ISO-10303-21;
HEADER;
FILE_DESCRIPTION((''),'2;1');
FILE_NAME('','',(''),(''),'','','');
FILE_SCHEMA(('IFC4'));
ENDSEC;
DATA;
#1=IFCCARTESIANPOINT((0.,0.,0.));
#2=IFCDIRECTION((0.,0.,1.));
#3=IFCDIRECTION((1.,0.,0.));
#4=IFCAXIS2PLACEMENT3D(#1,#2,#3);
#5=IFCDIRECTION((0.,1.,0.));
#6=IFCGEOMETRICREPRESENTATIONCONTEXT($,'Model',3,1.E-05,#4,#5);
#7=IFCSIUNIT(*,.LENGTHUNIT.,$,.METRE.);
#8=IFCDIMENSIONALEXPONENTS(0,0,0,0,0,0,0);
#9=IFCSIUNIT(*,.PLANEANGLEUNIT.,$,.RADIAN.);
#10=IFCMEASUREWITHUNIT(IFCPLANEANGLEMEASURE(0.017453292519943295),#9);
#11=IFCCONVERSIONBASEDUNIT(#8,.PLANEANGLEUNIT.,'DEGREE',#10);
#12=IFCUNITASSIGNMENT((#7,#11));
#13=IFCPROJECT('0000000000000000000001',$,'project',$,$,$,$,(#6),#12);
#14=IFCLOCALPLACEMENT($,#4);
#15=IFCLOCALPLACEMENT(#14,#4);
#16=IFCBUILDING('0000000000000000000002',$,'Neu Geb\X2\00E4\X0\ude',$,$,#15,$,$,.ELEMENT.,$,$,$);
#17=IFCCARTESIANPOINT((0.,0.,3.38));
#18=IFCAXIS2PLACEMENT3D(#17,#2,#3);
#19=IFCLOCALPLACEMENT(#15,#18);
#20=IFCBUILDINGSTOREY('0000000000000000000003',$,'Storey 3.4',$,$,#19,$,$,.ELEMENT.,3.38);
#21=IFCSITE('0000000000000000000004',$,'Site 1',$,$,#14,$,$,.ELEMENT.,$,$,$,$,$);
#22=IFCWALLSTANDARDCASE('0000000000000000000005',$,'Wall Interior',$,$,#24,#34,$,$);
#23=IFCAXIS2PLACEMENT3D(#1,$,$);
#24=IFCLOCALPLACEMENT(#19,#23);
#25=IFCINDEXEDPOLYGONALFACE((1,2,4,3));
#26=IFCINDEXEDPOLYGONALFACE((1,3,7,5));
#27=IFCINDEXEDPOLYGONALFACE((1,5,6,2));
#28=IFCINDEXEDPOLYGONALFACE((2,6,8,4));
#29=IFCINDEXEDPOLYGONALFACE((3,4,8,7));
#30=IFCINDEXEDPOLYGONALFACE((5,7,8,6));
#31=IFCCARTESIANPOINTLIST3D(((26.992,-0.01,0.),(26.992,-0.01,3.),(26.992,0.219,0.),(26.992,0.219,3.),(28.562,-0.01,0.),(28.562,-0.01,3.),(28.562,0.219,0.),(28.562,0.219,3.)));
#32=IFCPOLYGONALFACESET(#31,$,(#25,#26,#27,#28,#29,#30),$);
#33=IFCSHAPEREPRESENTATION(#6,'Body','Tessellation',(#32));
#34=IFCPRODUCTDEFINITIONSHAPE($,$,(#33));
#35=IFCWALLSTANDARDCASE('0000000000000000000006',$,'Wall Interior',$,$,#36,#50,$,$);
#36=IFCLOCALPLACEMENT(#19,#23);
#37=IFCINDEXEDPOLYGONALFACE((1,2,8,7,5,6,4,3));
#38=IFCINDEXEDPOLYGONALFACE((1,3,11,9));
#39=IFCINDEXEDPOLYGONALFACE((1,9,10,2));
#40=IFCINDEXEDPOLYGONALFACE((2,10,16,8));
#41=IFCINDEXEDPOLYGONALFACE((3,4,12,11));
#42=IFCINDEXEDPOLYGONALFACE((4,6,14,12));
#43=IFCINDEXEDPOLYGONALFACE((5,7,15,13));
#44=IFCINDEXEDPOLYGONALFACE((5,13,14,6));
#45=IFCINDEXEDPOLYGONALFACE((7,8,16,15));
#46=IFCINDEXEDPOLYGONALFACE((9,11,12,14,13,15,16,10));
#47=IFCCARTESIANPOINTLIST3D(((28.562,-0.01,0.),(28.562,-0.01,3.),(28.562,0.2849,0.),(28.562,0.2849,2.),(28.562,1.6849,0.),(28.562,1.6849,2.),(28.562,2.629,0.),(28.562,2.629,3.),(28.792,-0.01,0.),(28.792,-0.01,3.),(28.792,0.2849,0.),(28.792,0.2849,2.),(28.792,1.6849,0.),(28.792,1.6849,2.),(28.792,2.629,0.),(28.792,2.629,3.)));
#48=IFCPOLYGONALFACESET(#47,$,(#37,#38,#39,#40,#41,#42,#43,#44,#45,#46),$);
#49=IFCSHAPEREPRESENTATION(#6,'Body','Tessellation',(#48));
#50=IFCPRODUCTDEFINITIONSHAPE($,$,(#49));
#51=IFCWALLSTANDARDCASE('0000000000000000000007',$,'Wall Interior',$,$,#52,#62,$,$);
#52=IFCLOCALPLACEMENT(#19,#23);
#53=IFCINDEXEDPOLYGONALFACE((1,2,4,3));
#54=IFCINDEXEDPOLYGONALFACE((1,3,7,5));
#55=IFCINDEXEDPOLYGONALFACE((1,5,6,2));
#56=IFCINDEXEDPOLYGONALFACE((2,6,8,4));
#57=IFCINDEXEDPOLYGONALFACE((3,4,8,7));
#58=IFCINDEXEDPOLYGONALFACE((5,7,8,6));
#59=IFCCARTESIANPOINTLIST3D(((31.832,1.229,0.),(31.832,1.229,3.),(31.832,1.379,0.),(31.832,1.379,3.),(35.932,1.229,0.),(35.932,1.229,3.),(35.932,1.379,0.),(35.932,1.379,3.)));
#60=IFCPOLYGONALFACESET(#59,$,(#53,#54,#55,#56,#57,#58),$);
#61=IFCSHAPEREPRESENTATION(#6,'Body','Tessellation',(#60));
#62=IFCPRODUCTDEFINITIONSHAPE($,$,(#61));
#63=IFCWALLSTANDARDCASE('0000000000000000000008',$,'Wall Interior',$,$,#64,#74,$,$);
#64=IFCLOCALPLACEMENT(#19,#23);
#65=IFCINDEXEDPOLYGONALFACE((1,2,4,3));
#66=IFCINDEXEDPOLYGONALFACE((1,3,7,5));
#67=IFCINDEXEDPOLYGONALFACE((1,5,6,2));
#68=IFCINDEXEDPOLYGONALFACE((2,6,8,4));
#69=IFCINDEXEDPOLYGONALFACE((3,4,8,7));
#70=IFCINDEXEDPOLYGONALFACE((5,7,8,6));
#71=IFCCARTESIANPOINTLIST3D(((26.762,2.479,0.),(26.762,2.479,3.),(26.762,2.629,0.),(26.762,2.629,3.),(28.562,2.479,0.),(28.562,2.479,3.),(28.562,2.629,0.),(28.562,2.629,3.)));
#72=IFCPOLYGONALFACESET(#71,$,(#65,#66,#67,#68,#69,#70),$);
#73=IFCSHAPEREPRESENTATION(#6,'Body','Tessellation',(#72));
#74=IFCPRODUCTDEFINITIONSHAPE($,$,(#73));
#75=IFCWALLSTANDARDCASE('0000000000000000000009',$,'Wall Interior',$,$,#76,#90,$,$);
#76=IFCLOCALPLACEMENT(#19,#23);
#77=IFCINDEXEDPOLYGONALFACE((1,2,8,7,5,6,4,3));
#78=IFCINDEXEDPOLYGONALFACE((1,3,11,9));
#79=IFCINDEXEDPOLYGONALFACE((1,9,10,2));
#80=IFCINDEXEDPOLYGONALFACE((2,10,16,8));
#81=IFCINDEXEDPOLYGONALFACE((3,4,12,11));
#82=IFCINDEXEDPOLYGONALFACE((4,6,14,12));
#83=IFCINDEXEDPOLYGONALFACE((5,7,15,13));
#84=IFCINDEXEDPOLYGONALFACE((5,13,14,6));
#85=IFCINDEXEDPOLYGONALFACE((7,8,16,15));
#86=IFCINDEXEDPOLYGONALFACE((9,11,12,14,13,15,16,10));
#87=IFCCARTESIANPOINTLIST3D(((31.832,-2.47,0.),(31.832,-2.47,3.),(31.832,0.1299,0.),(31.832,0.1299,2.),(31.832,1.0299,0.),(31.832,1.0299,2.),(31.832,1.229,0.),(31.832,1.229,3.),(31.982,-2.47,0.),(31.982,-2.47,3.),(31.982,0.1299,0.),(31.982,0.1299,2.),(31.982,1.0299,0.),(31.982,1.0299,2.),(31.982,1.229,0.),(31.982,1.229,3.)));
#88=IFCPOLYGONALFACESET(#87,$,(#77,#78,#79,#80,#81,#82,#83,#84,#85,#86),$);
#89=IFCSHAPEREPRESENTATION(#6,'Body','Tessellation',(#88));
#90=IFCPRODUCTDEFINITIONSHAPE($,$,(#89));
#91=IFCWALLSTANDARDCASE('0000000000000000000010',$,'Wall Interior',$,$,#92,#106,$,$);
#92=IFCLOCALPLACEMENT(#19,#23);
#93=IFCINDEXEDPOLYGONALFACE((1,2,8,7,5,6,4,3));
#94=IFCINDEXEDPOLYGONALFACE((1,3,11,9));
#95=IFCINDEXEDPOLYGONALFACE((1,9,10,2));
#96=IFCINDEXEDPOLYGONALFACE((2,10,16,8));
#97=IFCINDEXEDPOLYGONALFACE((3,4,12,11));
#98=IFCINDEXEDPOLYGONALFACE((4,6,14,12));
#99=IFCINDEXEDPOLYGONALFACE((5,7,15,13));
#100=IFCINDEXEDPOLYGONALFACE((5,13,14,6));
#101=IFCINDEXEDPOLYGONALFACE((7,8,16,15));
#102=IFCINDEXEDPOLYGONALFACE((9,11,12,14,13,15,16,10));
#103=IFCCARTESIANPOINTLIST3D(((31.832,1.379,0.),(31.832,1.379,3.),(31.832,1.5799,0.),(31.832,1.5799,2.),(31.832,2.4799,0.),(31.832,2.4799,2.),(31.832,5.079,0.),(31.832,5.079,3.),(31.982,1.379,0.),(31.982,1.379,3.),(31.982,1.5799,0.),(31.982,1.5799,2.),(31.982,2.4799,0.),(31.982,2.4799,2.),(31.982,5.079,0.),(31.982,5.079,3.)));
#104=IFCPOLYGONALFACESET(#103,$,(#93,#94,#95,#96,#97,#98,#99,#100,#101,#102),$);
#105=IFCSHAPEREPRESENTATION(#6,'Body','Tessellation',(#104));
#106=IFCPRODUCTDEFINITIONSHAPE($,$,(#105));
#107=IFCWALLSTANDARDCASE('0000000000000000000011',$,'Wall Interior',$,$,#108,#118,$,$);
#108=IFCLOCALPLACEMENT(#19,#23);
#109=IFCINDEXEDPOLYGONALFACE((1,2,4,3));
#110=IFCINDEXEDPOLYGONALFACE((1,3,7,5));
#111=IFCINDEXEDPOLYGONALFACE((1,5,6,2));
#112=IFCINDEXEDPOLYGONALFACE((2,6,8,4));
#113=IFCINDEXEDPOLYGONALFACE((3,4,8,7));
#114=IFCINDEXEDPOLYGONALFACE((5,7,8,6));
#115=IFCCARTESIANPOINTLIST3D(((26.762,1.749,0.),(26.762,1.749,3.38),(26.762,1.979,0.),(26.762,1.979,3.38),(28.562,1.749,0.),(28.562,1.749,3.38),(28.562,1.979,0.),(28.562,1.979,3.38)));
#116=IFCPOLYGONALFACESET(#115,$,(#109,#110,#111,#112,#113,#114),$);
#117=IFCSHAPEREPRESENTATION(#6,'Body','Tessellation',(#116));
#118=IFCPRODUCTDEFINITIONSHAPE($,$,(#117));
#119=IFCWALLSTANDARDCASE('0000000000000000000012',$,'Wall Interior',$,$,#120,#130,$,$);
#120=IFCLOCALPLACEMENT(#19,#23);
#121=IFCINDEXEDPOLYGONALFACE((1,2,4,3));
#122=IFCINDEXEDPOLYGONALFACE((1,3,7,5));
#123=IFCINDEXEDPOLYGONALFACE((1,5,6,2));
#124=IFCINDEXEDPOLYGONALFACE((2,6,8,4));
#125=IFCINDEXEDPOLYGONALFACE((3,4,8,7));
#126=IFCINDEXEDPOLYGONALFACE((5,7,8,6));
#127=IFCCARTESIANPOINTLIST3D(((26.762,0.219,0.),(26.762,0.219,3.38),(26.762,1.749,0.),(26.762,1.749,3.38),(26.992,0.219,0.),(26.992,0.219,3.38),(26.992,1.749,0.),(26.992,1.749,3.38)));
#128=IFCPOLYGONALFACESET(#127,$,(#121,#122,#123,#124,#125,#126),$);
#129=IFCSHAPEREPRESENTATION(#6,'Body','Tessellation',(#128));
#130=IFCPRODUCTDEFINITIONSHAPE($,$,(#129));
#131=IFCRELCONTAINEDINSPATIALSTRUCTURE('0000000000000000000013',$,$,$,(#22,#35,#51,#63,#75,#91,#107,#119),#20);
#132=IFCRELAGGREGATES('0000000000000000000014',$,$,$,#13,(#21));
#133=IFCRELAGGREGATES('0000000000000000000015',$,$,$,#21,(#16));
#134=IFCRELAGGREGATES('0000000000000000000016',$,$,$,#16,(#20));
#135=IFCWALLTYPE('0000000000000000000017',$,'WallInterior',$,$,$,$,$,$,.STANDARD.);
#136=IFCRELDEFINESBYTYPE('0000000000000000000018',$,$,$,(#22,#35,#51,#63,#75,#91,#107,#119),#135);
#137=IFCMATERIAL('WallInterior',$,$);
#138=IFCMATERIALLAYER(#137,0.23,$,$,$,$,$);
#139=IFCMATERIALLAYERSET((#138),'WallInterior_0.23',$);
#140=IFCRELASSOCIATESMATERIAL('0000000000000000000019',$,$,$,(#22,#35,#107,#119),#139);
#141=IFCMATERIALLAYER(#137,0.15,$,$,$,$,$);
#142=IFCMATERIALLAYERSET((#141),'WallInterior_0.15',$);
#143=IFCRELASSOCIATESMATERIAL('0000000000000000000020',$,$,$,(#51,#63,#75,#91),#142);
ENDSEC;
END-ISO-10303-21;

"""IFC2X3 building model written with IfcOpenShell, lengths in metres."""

from ifc_helpers import new_model, entity, si_unit, converted_unit, direction, frame, origin_with_axes, place, context, project, spatial, polyline, outline, extrude, material, layer, layer_set, layer_usage, type_object, element, save


model = new_model("IFC2X3")

# Units and contexts
model_context = context("Model", 3, precision=1e-05, world=origin_with_axes(), true_north=direction((0.0, 1.0, 0.0)))
ifc_project = project(units=[si_unit("LENGTHUNIT", "METRE"), converted_unit("PLANEANGLEUNIT", "DEGREE", entity("IfcPlaneAngleMeasure", 0.017453292519943295), si_unit("PLANEANGLEUNIT", "RADIAN"), dimensions=[0, 0, 0, 0, 0, 0, 0])], contexts=[model_context])

# Site, building, storey
site_placement = place(None, origin_with_axes())
site = spatial("IfcSite", under=ifc_project, at=site_placement, Name="Site 1", CompositionType="ELEMENT")
building_placement = place(site_placement, origin_with_axes())
building = spatial("IfcBuilding", under=site, at=building_placement, Name="Neu Gebäude", CompositionType="ELEMENT")
storey_placement = place(building_placement, frame((0.0, 0.0, 3.38), z_axis=(0.0, 0.0, 1.0), x_axis=(1.0, 0.0, 0.0)))
storey = spatial("IfcBuildingStorey", under=building, at=storey_placement, Name="Storey 3.4", CompositionType="ELEMENT", Elevation=3.38)

# Wall
ifc_material_1 = material(Name="WallInterior")
ifc_layer_1 = layer(ifc_material_1, 0.23)
ifc_layer_set_1 = layer_set([ifc_layer_1], Name="WallInterior_0.23")
ifc_layer_usage_1 = layer_usage(ifc_layer_set_1, "AXIS2", "POSITIVE", -0.115)
wall_type_1 = type_object("IfcWallType", Name="WallInterior", PredefinedType="STANDARD")
wall_1_placement = place(storey_placement, frame((28.562, 0.1045, 0.0), z_axis=(0.0, 0.0, 1.0), x_axis=(-1.0, 0.0, 0.0)))
element("IfcWallStandardCase", 1, at=wall_1_placement, inside=storey, type_object=wall_type_1, material=ifc_layer_usage_1, Name="Wall Interior", context=model_context, shape_type="SweptSolid", body=[
    extrude(outline(polyline([(0.0, -0.1145), (1.57, -0.1145), (1.57, 0.1145), (0.0, 0.1145), (0.0, -0.1145)])), origin_with_axes(), (0.0, 0.0, 1.0), 3.0),
])

# Shared definitions
ifc_layer_2 = layer(ifc_material_1, 0.15)
ifc_layer_set_2 = layer_set([ifc_layer_2], Name="WallInterior_0.15")
ifc_layer_usage_2 = layer_usage(ifc_layer_set_2, "AXIS2", "POSITIVE", -0.075)

# Wall, opening
wall_2_placement = place(storey_placement, frame((28.677, -0.01, 0.0), z_axis=(0.0, 0.0, 1.0), x_axis=(0.0, 1.0, 0.0)))
wall_2 = element("IfcWallStandardCase", 2, at=wall_2_placement, inside=storey, type_object=wall_type_1, material=ifc_layer_usage_1, Name="Wall Interior", context=model_context, shape_type="SweptSolid", body=[
    extrude(outline(polyline([(2.639, -0.115), (2.639, 0.115), (0.0, 0.115), (0.0, -0.115), (2.639, -0.115)])), origin_with_axes(), (0.0, 0.0, 1.0), 3.0),
])
opening_1_placement = place(wall_2_placement, frame((0.9949, 0.0, 0.0), z_axis=(0.0, 0.0, 1.0), x_axis=(1.0, 0.0, 0.0)))
element("IfcOpeningElement", 3, at=opening_1_placement, cuts=wall_2, context=model_context, shape_type="SweptSolid", body=[
    extrude(outline(polyline([(-0.7, 0.252), (0.7, 0.252), (0.7, -0.252), (-0.7, -0.252), (-0.7, 0.252)])), origin_with_axes(), (0.0, 0.0, 1.0), 2.0),
])

# Walls
wall_3_placement = place(storey_placement, frame((35.932, 1.304, 0.0), z_axis=(0.0, 0.0, 1.0), x_axis=(-1.0, 0.0, 0.0)))
element("IfcWallStandardCase", 4, at=wall_3_placement, inside=storey, type_object=wall_type_1, material=ifc_layer_usage_2, Name="Wall Interior", context=model_context, shape_type="SweptSolid", body=[
    extrude(outline(polyline([(0.0, -0.075), (4.1, -0.075), (4.1, 0.075), (0.0, 0.075), (0.0, -0.075)])), origin_with_axes(), (0.0, 0.0, 1.0), 3.0),
])
wall_4_placement = place(storey_placement, frame((28.562, 2.554, 0.0), z_axis=(0.0, 0.0, 1.0), x_axis=(-1.0, 0.0, 0.0)))
element("IfcWallStandardCase", 5, at=wall_4_placement, inside=storey, type_object=wall_type_1, material=ifc_layer_usage_2, Name="Wall Interior", context=model_context, shape_type="SweptSolid", body=[
    extrude(outline(polyline([(0.0, -0.075), (1.8, -0.075), (1.8, 0.075), (0.0, 0.075), (0.0, -0.075)])), origin_with_axes(), (0.0, 0.0, 1.0), 3.0),
])

# Walls, openings
wall_5_placement = place(storey_placement, frame((31.907, -2.47, 0.0), z_axis=(0.0, 0.0, 1.0), x_axis=(0.0, 1.0, 0.0)))
wall_5 = element("IfcWallStandardCase", 6, at=wall_5_placement, inside=storey, type_object=wall_type_1, material=ifc_layer_usage_2, Name="Wall Interior", context=model_context, shape_type="SweptSolid", body=[
    extrude(outline(polyline([(3.699, -0.075), (3.699, 0.075), (0.0, 0.075), (0.0, -0.075), (3.699, -0.075)])), origin_with_axes(), (0.0, 0.0, 1.0), 3.0),
])
opening_2_placement = place(wall_5_placement, frame((3.0499, 0.0, 0.0), z_axis=(0.0, 0.0, 1.0), x_axis=(1.0, 0.0, 0.0)))
element("IfcOpeningElement", 7, at=opening_2_placement, cuts=wall_5, context=model_context, shape_type="SweptSolid", body=[
    extrude(outline(polyline([(-0.45, 0.172), (0.45, 0.172), (0.45, -0.172), (-0.45, -0.172), (-0.45, 0.172)])), origin_with_axes(), (0.0, 0.0, 1.0), 2.0),
])
wall_6_placement = place(storey_placement, frame((31.907, 1.379, 0.0), z_axis=(0.0, 0.0, 1.0), x_axis=(0.0, 1.0, 0.0)))
wall_6 = element("IfcWallStandardCase", 8, at=wall_6_placement, inside=storey, type_object=wall_type_1, material=ifc_layer_usage_2, Name="Wall Interior", context=model_context, shape_type="SweptSolid", body=[
    extrude(outline(polyline([(3.7, -0.075), (3.7, 0.075), (0.0, 0.075), (0.0, -0.075), (3.7, -0.075)])), origin_with_axes(), (0.0, 0.0, 1.0), 3.0),
])
opening_3_placement = place(wall_6_placement, frame((0.6509, 0.0, 0.0), z_axis=(0.0, 0.0, 1.0), x_axis=(1.0, 0.0, 0.0)))
element("IfcOpeningElement", 9, at=opening_3_placement, cuts=wall_6, context=model_context, shape_type="SweptSolid", body=[
    extrude(outline(polyline([(-0.45, 0.172), (0.45, 0.172), (0.45, -0.172), (-0.45, -0.172), (-0.45, 0.172)])), origin_with_axes(), (0.0, 0.0, 1.0), 2.0),
])

# Walls
wall_7_placement = place(storey_placement, frame((28.562, 1.864, 0.0), z_axis=(0.0, 0.0, 1.0), x_axis=(-1.0, 0.0, 0.0)))
element("IfcWallStandardCase", 10, at=wall_7_placement, inside=storey, type_object=wall_type_1, material=ifc_layer_usage_1, Name="Wall Interior", context=model_context, shape_type="SweptSolid", body=[
    extrude(outline(polyline([(0.0, -0.115), (1.8, -0.115), (1.8, 0.115), (0.0, 0.115), (0.0, -0.115)])), origin_with_axes(), (0.0, 0.0, 1.0), 3.38),
])
wall_8_placement = place(storey_placement, frame((26.877, 0.219, 0.0), z_axis=(0.0, 0.0, 1.0), x_axis=(0.0, 1.0, 0.0)))
element("IfcWallStandardCase", 11, at=wall_8_placement, inside=storey, type_object=wall_type_1, material=ifc_layer_usage_1, Name="Wall Interior", context=model_context, shape_type="SweptSolid", body=[
    extrude(outline(polyline([(1.53, -0.115), (1.53, 0.115), (0.0, 0.115), (0.0, -0.115), (1.53, -0.115)])), origin_with_axes(), (0.0, 0.0, 1.0), 3.38),
])

save(model, "model.ifc")
